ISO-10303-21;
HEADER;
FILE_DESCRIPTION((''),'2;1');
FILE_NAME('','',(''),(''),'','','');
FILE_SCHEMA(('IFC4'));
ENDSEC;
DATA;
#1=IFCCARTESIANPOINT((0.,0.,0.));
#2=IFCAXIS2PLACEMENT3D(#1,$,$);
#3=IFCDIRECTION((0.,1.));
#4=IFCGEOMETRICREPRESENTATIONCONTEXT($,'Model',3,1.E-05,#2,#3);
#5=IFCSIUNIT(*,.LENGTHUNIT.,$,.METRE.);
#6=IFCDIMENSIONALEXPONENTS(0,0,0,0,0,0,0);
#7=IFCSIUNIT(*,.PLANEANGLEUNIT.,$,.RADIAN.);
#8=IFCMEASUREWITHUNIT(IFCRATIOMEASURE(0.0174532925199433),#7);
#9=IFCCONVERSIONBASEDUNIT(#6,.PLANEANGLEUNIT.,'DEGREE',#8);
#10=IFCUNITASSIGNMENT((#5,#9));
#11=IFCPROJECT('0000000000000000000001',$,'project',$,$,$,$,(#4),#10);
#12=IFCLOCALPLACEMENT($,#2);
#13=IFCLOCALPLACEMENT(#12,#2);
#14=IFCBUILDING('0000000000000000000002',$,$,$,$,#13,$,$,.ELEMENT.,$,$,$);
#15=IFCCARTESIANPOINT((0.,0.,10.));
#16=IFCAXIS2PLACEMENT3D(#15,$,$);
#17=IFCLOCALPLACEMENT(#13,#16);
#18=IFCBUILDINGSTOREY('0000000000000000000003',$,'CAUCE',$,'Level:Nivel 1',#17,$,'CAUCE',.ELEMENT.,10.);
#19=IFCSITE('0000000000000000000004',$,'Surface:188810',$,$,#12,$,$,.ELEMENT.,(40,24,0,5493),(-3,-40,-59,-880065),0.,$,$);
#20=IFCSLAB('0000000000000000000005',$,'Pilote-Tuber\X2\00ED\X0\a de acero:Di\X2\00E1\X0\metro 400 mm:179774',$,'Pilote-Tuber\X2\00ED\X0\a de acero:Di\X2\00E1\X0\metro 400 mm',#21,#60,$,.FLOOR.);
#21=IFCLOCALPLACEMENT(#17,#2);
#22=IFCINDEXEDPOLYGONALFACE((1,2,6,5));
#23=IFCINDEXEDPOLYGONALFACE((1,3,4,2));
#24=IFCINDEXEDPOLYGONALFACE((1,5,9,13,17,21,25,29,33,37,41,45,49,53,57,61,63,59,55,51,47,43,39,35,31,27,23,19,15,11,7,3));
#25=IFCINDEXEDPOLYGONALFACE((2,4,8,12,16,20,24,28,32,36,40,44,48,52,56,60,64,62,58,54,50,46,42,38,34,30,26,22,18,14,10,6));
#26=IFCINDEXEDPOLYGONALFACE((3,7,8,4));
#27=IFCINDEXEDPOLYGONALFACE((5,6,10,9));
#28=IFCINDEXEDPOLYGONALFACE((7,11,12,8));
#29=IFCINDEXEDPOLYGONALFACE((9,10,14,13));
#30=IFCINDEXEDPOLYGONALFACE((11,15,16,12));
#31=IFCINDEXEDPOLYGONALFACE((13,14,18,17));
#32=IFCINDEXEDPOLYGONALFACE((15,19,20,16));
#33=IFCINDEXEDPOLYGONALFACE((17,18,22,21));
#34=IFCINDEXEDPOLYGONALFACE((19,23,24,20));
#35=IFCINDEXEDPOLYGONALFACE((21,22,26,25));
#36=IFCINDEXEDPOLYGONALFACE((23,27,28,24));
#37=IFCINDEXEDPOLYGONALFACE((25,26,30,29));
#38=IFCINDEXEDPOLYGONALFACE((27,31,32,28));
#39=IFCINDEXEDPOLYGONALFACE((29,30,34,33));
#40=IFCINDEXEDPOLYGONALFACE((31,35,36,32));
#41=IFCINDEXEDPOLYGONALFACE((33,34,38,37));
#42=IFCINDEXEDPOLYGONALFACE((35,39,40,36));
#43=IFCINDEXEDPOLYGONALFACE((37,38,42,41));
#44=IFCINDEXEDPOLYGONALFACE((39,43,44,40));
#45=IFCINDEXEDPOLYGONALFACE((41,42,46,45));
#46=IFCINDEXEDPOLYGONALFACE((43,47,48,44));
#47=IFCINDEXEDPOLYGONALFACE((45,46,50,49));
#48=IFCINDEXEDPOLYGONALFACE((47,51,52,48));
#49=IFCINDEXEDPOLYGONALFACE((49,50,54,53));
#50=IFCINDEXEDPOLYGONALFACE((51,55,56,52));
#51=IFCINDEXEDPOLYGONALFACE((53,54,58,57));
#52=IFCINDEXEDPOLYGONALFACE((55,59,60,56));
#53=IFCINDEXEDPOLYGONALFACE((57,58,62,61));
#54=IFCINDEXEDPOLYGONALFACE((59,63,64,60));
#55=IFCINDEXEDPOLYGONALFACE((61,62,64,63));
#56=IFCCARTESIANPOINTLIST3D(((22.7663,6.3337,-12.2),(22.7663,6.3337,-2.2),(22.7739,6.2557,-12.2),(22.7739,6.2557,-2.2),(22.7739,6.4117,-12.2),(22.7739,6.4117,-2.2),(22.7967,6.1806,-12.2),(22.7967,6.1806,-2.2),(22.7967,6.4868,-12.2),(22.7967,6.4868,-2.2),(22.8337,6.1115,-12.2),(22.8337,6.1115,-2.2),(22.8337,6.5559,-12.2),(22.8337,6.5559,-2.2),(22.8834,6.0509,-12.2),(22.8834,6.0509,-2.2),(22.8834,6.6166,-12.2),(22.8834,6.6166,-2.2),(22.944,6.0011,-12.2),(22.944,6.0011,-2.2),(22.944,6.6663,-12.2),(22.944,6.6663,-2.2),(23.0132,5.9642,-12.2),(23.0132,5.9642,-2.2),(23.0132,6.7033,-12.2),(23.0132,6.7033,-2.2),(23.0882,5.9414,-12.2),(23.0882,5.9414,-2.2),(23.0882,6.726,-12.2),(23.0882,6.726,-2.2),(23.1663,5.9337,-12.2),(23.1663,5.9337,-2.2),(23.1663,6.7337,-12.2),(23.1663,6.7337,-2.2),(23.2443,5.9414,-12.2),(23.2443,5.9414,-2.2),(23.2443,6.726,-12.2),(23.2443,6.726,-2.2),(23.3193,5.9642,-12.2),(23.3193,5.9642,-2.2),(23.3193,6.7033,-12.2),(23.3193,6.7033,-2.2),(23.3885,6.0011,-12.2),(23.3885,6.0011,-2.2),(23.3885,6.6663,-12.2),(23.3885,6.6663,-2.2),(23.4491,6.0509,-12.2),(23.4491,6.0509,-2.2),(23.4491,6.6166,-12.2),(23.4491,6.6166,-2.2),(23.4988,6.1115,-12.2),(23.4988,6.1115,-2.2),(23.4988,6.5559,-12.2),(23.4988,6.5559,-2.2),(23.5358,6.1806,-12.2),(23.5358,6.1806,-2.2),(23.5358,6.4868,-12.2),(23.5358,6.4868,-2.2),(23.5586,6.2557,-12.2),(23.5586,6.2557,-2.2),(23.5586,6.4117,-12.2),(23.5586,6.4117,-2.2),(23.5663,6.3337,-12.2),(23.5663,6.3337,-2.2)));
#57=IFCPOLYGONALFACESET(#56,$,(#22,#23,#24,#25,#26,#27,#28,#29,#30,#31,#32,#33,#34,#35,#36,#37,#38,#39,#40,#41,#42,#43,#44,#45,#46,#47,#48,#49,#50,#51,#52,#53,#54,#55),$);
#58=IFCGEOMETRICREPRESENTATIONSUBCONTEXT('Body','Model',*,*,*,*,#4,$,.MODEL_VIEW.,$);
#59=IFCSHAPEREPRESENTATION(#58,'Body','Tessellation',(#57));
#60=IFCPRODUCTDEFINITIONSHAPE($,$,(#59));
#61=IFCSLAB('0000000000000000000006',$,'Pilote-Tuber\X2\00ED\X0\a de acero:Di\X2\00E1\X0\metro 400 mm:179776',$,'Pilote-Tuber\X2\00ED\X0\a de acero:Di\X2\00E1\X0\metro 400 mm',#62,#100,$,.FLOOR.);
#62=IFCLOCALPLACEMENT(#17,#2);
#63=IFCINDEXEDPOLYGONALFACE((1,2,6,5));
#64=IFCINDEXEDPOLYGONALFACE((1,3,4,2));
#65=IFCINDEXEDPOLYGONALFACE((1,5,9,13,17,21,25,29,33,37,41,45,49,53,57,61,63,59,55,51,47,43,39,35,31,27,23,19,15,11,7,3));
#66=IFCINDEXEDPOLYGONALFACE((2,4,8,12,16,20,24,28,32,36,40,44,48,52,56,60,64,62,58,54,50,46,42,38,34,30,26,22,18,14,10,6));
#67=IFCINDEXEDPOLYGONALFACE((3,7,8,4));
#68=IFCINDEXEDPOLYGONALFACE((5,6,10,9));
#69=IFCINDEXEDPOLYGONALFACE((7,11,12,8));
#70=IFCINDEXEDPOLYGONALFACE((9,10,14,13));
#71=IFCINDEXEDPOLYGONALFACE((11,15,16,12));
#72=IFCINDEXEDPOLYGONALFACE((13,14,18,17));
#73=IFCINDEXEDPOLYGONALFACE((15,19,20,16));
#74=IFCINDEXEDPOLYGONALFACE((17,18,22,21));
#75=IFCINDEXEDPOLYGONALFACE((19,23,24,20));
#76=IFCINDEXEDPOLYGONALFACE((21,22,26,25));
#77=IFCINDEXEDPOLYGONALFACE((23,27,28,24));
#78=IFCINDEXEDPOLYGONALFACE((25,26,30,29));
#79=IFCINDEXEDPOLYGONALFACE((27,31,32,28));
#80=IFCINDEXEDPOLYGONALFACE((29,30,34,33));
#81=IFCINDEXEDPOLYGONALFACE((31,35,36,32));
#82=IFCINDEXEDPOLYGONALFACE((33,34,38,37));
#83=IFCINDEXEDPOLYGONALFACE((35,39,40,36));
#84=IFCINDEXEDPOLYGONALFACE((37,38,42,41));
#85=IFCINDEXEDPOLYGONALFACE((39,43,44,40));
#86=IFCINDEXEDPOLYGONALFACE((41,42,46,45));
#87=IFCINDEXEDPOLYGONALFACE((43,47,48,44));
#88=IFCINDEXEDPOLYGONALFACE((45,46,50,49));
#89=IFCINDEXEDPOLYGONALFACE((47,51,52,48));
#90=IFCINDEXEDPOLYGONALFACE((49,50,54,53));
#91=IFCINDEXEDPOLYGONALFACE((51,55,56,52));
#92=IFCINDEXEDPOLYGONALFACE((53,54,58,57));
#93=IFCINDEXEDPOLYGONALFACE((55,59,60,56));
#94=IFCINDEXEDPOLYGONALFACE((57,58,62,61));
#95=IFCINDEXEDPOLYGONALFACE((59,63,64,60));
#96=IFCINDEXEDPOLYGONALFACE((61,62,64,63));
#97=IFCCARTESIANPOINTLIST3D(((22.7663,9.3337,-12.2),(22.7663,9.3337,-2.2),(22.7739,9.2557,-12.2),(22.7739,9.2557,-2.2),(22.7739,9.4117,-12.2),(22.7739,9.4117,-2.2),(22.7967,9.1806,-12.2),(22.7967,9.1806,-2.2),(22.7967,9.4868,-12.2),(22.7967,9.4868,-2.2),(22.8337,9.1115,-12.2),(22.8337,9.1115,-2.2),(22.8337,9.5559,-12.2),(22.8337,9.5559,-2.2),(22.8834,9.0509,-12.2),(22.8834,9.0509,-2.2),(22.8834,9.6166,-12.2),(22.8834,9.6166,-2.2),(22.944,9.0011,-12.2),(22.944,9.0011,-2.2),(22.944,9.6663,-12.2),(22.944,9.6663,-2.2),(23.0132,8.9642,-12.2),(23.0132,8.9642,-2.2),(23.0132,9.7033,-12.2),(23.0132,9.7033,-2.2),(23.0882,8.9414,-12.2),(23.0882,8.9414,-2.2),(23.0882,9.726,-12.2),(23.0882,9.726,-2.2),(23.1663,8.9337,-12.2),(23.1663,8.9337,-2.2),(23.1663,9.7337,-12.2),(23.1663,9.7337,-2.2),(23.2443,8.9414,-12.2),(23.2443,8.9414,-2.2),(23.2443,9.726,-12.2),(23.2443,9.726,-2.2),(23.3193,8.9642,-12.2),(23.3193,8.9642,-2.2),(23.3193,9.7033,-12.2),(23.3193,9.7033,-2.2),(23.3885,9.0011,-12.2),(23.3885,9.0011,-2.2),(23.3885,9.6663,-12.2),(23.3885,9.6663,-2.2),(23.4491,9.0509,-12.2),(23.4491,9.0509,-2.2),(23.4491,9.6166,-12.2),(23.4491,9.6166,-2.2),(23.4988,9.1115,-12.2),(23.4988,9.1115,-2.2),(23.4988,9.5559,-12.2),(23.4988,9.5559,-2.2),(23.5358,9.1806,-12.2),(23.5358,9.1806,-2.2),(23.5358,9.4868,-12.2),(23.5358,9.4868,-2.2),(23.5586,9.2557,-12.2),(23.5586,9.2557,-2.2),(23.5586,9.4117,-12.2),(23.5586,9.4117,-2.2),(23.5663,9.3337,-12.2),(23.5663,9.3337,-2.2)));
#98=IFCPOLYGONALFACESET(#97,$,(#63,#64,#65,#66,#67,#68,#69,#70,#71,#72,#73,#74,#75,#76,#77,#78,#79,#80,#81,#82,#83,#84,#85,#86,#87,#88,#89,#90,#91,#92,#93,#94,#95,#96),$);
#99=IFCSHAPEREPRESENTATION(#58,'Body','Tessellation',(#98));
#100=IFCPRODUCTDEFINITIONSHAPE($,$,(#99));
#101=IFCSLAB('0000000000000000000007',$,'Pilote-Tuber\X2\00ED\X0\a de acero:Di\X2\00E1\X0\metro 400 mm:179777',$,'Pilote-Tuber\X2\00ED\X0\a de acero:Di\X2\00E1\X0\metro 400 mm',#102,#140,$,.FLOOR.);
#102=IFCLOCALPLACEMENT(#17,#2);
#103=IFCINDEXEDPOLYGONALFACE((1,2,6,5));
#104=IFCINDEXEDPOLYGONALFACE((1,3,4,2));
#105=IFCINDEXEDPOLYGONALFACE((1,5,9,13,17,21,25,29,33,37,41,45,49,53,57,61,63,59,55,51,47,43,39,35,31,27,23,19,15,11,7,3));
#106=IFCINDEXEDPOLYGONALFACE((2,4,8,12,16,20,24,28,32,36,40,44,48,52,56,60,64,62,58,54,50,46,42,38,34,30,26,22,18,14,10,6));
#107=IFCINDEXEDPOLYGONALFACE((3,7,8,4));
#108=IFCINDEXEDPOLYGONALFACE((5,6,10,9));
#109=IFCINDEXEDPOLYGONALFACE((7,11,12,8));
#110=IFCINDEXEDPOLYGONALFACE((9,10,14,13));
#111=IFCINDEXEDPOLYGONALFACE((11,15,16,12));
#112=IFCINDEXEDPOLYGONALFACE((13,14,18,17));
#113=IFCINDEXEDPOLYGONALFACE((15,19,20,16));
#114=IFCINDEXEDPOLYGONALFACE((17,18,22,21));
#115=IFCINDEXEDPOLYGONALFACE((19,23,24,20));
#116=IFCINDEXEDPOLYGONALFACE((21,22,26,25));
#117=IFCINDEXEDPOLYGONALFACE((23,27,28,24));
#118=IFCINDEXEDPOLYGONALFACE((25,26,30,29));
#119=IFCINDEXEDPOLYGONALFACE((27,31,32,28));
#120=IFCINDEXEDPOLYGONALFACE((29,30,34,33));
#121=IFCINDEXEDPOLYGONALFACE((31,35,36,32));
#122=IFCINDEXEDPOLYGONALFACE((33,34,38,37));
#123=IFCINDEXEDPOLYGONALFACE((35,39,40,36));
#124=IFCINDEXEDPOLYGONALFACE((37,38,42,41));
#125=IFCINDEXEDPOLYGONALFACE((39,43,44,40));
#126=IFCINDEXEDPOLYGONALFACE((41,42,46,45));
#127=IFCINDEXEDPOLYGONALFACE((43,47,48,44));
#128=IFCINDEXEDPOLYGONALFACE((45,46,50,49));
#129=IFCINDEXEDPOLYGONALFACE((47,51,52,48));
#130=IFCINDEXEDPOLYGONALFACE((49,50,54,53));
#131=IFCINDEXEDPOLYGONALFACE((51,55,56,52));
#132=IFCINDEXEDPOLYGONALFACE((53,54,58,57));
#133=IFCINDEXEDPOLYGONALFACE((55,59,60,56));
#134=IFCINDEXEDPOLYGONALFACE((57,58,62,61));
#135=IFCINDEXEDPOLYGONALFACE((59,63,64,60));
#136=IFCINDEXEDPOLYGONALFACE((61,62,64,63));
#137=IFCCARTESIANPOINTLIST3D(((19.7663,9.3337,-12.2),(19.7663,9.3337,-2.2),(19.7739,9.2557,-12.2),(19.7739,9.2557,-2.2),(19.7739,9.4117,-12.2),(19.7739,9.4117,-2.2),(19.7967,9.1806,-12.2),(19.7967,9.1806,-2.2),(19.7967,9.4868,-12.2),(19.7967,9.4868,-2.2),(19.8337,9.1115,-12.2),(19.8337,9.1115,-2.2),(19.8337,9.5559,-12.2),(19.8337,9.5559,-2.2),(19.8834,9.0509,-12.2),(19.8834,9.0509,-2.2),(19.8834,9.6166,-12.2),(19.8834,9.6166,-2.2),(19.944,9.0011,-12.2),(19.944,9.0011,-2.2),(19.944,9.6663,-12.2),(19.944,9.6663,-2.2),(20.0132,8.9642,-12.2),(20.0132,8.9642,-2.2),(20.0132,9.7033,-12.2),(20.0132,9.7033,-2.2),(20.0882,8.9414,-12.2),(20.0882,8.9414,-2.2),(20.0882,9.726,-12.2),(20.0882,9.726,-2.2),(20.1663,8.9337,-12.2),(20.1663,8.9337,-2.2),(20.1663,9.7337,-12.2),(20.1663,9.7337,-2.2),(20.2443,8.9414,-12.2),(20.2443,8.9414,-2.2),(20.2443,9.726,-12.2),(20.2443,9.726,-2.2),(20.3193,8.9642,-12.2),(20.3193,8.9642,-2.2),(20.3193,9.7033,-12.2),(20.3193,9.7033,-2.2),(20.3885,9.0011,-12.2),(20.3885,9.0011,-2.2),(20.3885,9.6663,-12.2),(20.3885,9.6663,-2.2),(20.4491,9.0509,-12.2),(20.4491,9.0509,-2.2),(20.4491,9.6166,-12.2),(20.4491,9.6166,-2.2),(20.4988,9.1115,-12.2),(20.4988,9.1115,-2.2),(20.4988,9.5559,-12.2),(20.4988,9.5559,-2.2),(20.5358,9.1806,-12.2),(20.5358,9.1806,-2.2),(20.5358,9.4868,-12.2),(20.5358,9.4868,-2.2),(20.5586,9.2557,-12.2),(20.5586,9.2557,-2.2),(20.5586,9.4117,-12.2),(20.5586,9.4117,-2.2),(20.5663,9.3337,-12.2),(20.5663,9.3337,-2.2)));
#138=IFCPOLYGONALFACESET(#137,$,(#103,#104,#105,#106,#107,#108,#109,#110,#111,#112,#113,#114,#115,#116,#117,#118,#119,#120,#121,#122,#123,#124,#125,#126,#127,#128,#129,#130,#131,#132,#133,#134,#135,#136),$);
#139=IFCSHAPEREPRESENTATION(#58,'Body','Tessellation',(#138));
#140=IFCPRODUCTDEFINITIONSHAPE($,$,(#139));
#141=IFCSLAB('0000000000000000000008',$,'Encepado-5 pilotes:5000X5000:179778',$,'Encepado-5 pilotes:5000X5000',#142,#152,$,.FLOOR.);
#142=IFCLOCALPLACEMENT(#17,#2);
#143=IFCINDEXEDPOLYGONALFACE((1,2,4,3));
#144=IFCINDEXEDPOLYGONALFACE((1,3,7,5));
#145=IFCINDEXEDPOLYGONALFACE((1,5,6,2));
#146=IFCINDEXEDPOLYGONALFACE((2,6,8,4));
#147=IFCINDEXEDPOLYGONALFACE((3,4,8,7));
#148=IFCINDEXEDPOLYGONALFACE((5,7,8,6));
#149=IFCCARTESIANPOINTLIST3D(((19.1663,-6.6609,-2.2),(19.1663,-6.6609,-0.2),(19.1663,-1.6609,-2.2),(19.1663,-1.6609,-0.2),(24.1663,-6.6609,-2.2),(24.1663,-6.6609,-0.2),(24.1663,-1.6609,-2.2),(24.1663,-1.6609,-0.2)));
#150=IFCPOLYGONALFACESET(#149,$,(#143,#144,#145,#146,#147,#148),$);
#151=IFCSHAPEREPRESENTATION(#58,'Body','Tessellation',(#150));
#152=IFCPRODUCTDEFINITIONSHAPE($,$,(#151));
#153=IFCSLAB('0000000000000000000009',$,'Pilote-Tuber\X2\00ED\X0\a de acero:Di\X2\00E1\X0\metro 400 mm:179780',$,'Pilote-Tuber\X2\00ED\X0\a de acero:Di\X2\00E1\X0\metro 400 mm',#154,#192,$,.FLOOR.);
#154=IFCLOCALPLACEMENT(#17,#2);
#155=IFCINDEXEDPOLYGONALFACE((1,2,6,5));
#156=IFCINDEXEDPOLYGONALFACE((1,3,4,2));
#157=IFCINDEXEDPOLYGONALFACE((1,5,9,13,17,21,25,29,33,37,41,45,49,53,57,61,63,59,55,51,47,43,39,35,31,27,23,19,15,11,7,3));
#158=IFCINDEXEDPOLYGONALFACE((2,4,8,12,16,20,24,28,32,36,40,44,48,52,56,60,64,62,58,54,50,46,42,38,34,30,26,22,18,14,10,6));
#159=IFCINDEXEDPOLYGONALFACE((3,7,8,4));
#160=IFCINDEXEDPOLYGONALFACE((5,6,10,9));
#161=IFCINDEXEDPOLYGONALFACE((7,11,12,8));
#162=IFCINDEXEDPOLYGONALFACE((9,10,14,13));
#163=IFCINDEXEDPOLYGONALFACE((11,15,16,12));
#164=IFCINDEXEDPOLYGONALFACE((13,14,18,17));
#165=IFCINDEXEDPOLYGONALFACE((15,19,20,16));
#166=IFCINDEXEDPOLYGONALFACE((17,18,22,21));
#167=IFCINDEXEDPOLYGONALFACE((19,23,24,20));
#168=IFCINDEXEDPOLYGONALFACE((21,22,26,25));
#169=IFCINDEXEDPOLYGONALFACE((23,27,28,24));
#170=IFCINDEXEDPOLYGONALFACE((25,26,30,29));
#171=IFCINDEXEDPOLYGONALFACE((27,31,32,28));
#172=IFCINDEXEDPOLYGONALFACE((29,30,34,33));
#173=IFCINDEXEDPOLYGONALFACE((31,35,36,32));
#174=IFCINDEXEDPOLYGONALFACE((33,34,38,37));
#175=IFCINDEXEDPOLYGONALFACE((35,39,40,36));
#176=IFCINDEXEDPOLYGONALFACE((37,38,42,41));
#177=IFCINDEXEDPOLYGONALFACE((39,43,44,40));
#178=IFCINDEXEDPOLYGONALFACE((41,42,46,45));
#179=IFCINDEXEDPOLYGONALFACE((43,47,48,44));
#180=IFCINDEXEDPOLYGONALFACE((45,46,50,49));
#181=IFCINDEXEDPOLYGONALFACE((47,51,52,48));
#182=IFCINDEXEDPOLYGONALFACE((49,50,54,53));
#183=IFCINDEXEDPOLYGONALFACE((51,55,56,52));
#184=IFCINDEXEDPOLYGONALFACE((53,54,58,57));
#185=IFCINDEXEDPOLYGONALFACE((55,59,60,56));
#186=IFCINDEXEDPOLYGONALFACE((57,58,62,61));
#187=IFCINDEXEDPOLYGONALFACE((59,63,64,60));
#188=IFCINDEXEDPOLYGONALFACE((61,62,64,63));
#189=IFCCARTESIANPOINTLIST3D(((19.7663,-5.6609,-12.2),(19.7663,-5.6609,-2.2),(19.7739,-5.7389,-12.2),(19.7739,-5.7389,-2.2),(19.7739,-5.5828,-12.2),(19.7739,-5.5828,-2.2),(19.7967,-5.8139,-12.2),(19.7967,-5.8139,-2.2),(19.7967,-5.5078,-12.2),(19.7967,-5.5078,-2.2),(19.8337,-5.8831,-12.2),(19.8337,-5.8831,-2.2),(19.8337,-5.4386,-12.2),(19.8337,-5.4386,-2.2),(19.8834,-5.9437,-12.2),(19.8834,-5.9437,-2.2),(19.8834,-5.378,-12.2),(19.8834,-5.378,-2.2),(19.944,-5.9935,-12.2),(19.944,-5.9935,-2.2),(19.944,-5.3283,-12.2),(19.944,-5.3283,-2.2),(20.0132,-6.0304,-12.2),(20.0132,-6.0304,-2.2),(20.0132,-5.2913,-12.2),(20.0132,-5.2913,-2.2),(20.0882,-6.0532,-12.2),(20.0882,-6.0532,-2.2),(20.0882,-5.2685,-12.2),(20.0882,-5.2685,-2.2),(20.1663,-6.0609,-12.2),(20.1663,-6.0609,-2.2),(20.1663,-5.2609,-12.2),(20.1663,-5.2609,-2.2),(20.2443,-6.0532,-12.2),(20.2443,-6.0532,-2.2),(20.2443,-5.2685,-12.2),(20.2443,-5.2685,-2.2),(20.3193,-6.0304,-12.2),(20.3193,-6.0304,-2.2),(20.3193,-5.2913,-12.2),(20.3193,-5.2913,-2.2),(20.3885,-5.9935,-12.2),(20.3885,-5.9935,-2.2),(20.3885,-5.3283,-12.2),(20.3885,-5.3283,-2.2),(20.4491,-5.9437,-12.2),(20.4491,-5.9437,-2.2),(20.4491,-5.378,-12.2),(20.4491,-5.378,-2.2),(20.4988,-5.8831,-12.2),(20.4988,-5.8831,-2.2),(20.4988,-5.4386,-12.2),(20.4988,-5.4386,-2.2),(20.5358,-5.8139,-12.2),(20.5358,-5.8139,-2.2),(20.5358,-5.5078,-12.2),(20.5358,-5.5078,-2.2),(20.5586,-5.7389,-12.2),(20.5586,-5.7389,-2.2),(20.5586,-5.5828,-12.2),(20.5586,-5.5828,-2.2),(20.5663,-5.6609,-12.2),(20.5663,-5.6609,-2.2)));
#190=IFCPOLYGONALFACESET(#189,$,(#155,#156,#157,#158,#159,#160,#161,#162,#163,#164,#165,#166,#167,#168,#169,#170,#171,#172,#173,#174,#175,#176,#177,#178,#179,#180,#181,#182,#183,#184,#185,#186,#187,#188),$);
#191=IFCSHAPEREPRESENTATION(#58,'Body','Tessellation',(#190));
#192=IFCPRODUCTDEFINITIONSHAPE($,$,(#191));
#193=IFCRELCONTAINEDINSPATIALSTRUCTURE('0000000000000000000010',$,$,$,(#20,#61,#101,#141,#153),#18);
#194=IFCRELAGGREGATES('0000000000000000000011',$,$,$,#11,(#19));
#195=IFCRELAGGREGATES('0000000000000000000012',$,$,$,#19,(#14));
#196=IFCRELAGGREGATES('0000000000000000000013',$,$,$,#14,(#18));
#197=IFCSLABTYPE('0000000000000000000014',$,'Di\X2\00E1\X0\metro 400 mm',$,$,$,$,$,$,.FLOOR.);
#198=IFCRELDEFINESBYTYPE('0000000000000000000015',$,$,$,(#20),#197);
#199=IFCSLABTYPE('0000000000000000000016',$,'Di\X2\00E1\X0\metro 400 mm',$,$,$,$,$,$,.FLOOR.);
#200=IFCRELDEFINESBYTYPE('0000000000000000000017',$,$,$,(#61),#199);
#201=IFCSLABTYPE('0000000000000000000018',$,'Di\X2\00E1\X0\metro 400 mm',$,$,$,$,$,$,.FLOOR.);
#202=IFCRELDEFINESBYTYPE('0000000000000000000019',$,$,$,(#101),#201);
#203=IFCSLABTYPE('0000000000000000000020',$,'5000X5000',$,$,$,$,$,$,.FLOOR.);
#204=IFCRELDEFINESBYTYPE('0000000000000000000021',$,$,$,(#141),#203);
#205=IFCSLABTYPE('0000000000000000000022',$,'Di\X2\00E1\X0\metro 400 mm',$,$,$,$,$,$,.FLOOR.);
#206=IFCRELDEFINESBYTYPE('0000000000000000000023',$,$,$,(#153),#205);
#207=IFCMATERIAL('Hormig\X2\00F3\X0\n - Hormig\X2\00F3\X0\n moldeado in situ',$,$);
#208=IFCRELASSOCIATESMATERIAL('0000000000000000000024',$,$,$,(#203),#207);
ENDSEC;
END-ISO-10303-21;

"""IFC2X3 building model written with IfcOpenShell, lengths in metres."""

from ifc_helpers import new_model, entity, si_unit, converted_unit, direction, frame, frame_2d, origin, origin_2d_with_axis, place, context, subcontext, project, spatial, rectangle, circle, extrude, material, type_object, element, save


model = new_model("IFC2X3")

# Units and contexts
model_context = context("Model", 3, precision=1e-05, world=origin(), true_north=direction((0.0, 1.0)))
body_context = subcontext(model_context, "Body", "Model", "MODEL_VIEW")
ifc_project = project(units=[si_unit("LENGTHUNIT", "METRE"), converted_unit("PLANEANGLEUNIT", "DEGREE", entity("IfcRatioMeasure", 0.0174532925199433), si_unit("PLANEANGLEUNIT", "RADIAN"), dimensions=[0, 0, 0, 0, 0, 0, 0])], contexts=[model_context])

# Site, building, storey
site_placement = place(None, origin())
site = spatial("IfcSite", under=ifc_project, at=site_placement, Name="Surface:188810", CompositionType="ELEMENT", RefLatitude=(40, 24, 0, 5493), RefLongitude=(-3, -40, -59, -880065), RefElevation=0.0)
building_placement = place(site_placement, origin())
building = spatial("IfcBuilding", under=site, at=building_placement, CompositionType="ELEMENT")
storey_placement = place(building_placement, frame((0.0, 0.0, 10.0)))
storey = spatial("IfcBuildingStorey", under=building, at=storey_placement, Name="CAUCE", ObjectType="Level:Nivel 1", LongName="CAUCE", CompositionType="ELEMENT", Elevation=10.0)

# Slabs
ifc_material = material(Name="Hormigón - Hormigón moldeado in situ")
slab_type_1 = type_object("IfcSlabType", Name="Diámetro 400 mm", PredefinedType="FLOOR")
slab_1_placement = place(storey_placement, origin())
element("IfcSlab", 1, at=slab_1_placement, inside=storey, type_object=slab_type_1, Name="Pilote-Tubería de acero:Diámetro 400 mm:179774", ObjectType="Pilote-Tubería de acero:Diámetro 400 mm", PredefinedType="FLOOR", context=body_context, shape_type="SweptSolid", body=[
    extrude(circle(Radius=0.4, at=origin_2d_with_axis()), frame((23.1663, 6.3337, -12.2)), (0.0, 0.0, 1.0), 10.0),
])
slab_type_2 = type_object("IfcSlabType", Name="Diámetro 400 mm", PredefinedType="FLOOR")
slab_2_placement = place(storey_placement, origin())
element("IfcSlab", 2, at=slab_2_placement, inside=storey, type_object=slab_type_2, Name="Pilote-Tubería de acero:Diámetro 400 mm:179776", ObjectType="Pilote-Tubería de acero:Diámetro 400 mm", PredefinedType="FLOOR", context=body_context, shape_type="SweptSolid", body=[
    extrude(circle(Radius=0.4, at=origin_2d_with_axis()), frame((23.1663, 9.3337, -12.2)), (0.0, 0.0, 1.0), 10.0),
])
slab_type_3 = type_object("IfcSlabType", Name="Diámetro 400 mm", PredefinedType="FLOOR")
slab_3_placement = place(storey_placement, origin())
element("IfcSlab", 3, at=slab_3_placement, inside=storey, type_object=slab_type_3, Name="Pilote-Tubería de acero:Diámetro 400 mm:179777", ObjectType="Pilote-Tubería de acero:Diámetro 400 mm", PredefinedType="FLOOR", context=body_context, shape_type="SweptSolid", body=[
    extrude(circle(Radius=0.4, at=origin_2d_with_axis()), frame((20.1663, 9.3337, -12.2)), (0.0, 0.0, 1.0), 10.0),
])
slab_type_4 = type_object("IfcSlabType", Name="5000X5000", PredefinedType="FLOOR", material=ifc_material)
slab_4_placement = place(storey_placement, origin())
element("IfcSlab", 4, at=slab_4_placement, inside=storey, type_object=slab_type_4, Name="Encepado-5 pilotes:5000X5000:179778", ObjectType="Encepado-5 pilotes:5000X5000", PredefinedType="FLOOR", context=body_context, shape_type="SweptSolid", body=[
    extrude(rectangle(XDim=5.0, YDim=5.0, at=frame_2d((0.0, 0.0), x_axis=(1.0, 0.0))), frame((21.6663, -4.1609, -2.2), z_axis=(0.0, 0.0, 1.0), x_axis=(-1.0, 0.0, 0.0)), (0.0, 0.0, 1.0), 2.0),
])
slab_type_5 = type_object("IfcSlabType", Name="Diámetro 400 mm", PredefinedType="FLOOR")
slab_5_placement = place(storey_placement, origin())
element("IfcSlab", 5, at=slab_5_placement, inside=storey, type_object=slab_type_5, Name="Pilote-Tubería de acero:Diámetro 400 mm:179780", ObjectType="Pilote-Tubería de acero:Diámetro 400 mm", PredefinedType="FLOOR", context=body_context, shape_type="SweptSolid", body=[
    extrude(circle(Radius=0.4, at=frame_2d((0.0, 0.0), x_axis=(1.0, 0.0))), frame((20.1663, -5.6609, -12.2)), (0.0, 0.0, 1.0), 10.0),
])

save(model, "model.ifc")
